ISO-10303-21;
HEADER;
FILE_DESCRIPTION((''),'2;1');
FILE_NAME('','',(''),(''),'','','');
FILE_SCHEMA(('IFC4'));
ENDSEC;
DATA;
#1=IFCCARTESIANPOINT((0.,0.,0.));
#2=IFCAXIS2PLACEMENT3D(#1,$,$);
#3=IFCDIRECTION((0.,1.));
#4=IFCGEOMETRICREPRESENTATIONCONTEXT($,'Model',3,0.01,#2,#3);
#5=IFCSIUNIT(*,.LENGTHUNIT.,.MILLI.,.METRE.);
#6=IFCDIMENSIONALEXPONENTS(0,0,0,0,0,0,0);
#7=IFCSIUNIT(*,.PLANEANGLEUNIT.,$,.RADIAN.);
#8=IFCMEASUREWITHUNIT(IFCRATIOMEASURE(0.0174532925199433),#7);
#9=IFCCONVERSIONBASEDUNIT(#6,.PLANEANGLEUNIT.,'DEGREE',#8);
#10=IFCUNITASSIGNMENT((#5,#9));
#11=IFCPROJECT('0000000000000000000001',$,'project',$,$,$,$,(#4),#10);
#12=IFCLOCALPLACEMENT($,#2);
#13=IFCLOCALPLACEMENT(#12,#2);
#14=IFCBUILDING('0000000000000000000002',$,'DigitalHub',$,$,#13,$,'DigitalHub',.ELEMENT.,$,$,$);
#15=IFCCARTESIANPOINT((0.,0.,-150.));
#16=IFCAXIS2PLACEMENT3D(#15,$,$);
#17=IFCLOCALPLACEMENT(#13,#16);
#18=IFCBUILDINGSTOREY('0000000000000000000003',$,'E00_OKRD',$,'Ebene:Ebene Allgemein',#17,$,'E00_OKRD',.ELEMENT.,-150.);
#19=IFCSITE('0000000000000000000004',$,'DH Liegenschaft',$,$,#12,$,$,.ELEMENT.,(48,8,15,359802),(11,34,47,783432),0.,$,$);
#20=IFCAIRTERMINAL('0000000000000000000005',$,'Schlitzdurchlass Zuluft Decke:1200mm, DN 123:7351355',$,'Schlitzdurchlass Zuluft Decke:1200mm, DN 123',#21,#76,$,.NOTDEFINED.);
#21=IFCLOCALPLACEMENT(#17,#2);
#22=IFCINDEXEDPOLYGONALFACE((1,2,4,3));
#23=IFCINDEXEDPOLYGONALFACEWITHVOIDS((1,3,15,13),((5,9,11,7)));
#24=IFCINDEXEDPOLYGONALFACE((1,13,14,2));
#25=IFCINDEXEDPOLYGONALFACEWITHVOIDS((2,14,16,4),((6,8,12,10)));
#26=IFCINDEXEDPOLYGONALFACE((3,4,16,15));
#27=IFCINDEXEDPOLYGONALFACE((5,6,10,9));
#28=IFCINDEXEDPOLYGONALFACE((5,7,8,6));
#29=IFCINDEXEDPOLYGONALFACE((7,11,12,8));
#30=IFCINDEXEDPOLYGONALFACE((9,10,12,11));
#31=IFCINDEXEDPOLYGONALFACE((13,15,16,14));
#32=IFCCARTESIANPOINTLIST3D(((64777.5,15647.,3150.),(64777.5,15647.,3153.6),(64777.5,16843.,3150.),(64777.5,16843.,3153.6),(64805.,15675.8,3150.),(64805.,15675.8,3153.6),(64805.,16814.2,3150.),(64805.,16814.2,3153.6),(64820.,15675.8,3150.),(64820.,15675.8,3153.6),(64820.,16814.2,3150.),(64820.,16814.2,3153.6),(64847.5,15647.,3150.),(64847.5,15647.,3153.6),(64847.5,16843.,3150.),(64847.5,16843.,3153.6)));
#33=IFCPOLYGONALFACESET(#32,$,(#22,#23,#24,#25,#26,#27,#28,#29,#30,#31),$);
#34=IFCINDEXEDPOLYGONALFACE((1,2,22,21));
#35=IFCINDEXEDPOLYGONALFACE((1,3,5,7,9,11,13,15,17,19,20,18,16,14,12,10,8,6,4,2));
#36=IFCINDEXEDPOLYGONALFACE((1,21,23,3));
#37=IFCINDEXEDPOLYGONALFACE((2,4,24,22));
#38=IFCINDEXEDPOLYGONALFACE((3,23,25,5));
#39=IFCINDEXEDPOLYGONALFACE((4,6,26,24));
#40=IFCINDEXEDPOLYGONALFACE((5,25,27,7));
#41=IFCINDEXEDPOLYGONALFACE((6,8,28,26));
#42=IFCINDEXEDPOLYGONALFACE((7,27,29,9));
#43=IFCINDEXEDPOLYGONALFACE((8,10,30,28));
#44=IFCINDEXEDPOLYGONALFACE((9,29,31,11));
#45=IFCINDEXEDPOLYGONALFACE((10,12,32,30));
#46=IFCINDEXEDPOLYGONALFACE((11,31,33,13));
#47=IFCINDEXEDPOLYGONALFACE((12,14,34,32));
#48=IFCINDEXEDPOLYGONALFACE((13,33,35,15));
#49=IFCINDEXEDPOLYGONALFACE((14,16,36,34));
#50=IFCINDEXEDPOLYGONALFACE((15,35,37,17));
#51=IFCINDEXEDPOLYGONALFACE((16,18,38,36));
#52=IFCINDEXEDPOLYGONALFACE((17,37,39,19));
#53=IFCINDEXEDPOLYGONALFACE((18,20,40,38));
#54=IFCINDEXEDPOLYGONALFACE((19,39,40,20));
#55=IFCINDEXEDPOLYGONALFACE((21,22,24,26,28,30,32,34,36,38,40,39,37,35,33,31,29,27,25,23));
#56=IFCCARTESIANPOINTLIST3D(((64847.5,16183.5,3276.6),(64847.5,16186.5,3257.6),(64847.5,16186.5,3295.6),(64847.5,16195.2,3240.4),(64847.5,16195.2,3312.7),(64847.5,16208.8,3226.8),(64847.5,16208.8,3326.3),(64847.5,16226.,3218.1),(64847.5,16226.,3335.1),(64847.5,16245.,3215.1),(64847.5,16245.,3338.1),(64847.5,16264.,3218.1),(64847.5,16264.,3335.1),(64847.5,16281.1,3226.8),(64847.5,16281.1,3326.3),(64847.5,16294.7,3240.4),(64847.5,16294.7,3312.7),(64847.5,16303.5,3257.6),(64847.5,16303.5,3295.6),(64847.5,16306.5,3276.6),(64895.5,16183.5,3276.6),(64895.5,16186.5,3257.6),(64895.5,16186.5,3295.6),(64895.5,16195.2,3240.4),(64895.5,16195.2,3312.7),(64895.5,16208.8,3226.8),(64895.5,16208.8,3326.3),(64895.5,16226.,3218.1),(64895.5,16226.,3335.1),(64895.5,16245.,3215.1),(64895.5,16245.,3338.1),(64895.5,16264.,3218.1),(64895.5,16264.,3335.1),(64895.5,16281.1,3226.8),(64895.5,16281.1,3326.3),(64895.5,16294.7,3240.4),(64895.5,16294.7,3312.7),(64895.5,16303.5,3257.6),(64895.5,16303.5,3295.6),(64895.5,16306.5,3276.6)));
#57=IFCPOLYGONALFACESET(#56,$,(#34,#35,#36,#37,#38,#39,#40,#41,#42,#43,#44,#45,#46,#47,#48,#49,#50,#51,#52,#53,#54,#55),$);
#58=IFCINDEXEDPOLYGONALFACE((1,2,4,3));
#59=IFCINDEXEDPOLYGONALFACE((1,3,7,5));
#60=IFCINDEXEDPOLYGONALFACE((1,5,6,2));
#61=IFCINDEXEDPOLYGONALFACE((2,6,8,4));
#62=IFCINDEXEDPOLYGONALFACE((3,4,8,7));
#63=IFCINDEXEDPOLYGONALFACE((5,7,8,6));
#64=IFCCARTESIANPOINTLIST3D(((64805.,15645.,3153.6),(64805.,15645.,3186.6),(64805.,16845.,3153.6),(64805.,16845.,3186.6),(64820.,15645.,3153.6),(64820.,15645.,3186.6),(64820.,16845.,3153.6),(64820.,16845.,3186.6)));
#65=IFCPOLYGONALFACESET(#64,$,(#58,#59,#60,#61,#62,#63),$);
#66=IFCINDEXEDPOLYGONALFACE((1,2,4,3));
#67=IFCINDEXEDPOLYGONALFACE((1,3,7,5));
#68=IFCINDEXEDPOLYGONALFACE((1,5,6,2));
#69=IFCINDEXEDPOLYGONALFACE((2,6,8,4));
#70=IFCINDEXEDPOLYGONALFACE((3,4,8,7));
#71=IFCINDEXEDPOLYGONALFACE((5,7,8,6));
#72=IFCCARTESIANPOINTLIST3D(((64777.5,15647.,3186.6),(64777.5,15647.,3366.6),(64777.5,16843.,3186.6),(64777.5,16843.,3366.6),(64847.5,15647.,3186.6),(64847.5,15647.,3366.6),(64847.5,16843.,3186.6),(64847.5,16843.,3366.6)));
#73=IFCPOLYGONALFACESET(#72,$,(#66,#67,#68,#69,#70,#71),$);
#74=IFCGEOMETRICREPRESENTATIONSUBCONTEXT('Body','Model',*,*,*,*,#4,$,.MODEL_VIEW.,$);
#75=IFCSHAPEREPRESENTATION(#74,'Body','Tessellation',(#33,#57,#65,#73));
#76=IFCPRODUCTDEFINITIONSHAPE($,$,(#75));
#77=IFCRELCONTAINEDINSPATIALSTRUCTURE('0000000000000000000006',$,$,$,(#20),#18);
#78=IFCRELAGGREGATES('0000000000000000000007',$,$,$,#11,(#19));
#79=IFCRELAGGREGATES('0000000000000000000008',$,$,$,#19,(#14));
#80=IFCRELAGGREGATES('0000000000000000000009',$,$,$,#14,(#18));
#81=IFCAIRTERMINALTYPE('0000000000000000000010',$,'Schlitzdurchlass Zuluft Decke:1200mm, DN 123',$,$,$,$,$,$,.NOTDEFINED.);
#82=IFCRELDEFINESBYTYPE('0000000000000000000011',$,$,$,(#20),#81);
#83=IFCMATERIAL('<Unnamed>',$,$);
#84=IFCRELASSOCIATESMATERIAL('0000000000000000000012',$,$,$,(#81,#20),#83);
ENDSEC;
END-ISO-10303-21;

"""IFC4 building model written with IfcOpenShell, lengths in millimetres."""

from ifc_helpers import new_model, entity, si_unit, converted_unit, direction, frame, origin, place, context, subcontext, project, spatial, indexed_curve, outline, extrude, source, transform, mapped, material, type_object, type_shapes, element, save


model = new_model("IFC4")

# Units and contexts
model_context = context("Model", 3, precision=0.01, world=origin(), true_north=direction((0.0, 1.0)))
body_context = subcontext(model_context, "Body", "Model", "MODEL_VIEW")
ifc_project = project(units=[si_unit("LENGTHUNIT", "METRE", prefix="MILLI"), converted_unit("PLANEANGLEUNIT", "DEGREE", entity("IfcRatioMeasure", 0.0174532925199433), si_unit("PLANEANGLEUNIT", "RADIAN"), dimensions=[0, 0, 0, 0, 0, 0, 0])], contexts=[model_context])

# Site, building, storey
site_placement = place(None, origin())
site = spatial("IfcSite", under=ifc_project, at=site_placement, Name="DH Liegenschaft", CompositionType="ELEMENT", RefLatitude=(48, 8, 15, 359802), RefLongitude=(11, 34, 47, 783432), RefElevation=0.0)
building_placement = place(site_placement, origin())
building = spatial("IfcBuilding", under=site, at=building_placement, Name="DigitalHub", LongName="DigitalHub", CompositionType="ELEMENT")
storey_placement = place(building_placement, frame((0.0, 0.0, -150.0)))
storey = spatial("IfcBuildingStorey", under=building, at=storey_placement, Name="E00_OKRD", ObjectType="Ebene:Ebene Allgemein", LongName="E00_OKRD", CompositionType="ELEMENT", Elevation=-150.0)

# Shared definitions
ifc_material_1 = material(Name="<Unnamed>")

# Air terminal
air_terminal_type_1 = type_object("IfcAirTerminalType", Name="Schlitzdurchlass Zuluft Decke:1200mm, DN 123", PredefinedType="NOTDEFINED", material=ifc_material_1)
shared_shape_1 = source(origin(), body_context, "Body", "SweptSolid", [
    extrude(outline(indexed_curve([(-598.0, -35.0), (598.0, -35.0), (598.0, 35.0), (-598.0, 35.0), (-598.0, -35.0)], self_intersect=False), holes=[indexed_curve([(-569.2, -7.5), (-569.2, 7.5), (569.2, 7.5), (569.2, -7.5), (-569.2, -7.5)], self_intersect=False)]), frame((600.0, 35.0, 0.0), z_axis=(0.0, 0.0, 1.0), x_axis=(-1.0, 0.0, 0.0)), (0.0, 0.0, 1.0), 3.6),
    extrude(outline(indexed_curve([(61.5, 0.0), (58.5, 19.0), (49.8, 36.1), (36.1, 49.8), (19.0, 58.5), (0.0, 61.5), (-19.0, 58.5), (-36.1, 49.8), (-49.8, 36.1), (-58.5, 19.0), (-61.5, 0.0), (-58.5, -19.0), (-49.8, -36.1), (-36.1, -49.8), (-19.0, -58.5), (0.0, -61.5), (19.0, -58.5), (36.1, -49.8), (49.8, -36.1), (58.5, -19.0), (61.5, 0.0)], self_intersect=False)), frame((600.0, 70.0, 126.6), z_axis=(0.0, 1.0, 0.0), x_axis=(-1.0, 0.0, 0.0)), (0.0, 0.0, 1.0), 48.0),
    extrude(outline(indexed_curve([(-600.0, -7.5), (600.0, -7.5), (600.0, 7.5), (-600.0, 7.5), (-600.0, -7.5)], self_intersect=False)), frame((600.0, 35.0, 3.6), z_axis=(0.0, 0.0, 1.0), x_axis=(-1.0, 0.0, 0.0)), (0.0, 0.0, 1.0), 33.0),
    extrude(outline(indexed_curve([(-598.0, -35.0), (598.0, -35.0), (598.0, 35.0), (-598.0, 35.0), (-598.0, -35.0)], self_intersect=False)), frame((600.0, 35.0, 36.6), z_axis=(0.0, 0.0, 1.0), x_axis=(-1.0, 0.0, 0.0)), (0.0, 0.0, 1.0), 180.0),
])
type_shapes(air_terminal_type_1, [shared_shape_1])
air_terminal_1_placement = place(storey_placement, frame((64777.5, 16845.0, 3150.0), z_axis=(0.0, 0.0, 1.0), x_axis=(0.0, -1.0, 0.0)))
element("IfcAirTerminal", 1, at=air_terminal_1_placement, inside=storey, type_object=air_terminal_type_1, material=ifc_material_1, Name="Schlitzdurchlass Zuluft Decke:1200mm, DN 123:7351355", ObjectType="Schlitzdurchlass Zuluft Decke:1200mm, DN 123", PredefinedType="NOTDEFINED", context=body_context, shape_type="MappedRepresentation", body=[
    mapped(shared_shape_1, transform((0.0, 0.0, 0.0), scale=1.0)),
])

save(model, "model.ifc")
